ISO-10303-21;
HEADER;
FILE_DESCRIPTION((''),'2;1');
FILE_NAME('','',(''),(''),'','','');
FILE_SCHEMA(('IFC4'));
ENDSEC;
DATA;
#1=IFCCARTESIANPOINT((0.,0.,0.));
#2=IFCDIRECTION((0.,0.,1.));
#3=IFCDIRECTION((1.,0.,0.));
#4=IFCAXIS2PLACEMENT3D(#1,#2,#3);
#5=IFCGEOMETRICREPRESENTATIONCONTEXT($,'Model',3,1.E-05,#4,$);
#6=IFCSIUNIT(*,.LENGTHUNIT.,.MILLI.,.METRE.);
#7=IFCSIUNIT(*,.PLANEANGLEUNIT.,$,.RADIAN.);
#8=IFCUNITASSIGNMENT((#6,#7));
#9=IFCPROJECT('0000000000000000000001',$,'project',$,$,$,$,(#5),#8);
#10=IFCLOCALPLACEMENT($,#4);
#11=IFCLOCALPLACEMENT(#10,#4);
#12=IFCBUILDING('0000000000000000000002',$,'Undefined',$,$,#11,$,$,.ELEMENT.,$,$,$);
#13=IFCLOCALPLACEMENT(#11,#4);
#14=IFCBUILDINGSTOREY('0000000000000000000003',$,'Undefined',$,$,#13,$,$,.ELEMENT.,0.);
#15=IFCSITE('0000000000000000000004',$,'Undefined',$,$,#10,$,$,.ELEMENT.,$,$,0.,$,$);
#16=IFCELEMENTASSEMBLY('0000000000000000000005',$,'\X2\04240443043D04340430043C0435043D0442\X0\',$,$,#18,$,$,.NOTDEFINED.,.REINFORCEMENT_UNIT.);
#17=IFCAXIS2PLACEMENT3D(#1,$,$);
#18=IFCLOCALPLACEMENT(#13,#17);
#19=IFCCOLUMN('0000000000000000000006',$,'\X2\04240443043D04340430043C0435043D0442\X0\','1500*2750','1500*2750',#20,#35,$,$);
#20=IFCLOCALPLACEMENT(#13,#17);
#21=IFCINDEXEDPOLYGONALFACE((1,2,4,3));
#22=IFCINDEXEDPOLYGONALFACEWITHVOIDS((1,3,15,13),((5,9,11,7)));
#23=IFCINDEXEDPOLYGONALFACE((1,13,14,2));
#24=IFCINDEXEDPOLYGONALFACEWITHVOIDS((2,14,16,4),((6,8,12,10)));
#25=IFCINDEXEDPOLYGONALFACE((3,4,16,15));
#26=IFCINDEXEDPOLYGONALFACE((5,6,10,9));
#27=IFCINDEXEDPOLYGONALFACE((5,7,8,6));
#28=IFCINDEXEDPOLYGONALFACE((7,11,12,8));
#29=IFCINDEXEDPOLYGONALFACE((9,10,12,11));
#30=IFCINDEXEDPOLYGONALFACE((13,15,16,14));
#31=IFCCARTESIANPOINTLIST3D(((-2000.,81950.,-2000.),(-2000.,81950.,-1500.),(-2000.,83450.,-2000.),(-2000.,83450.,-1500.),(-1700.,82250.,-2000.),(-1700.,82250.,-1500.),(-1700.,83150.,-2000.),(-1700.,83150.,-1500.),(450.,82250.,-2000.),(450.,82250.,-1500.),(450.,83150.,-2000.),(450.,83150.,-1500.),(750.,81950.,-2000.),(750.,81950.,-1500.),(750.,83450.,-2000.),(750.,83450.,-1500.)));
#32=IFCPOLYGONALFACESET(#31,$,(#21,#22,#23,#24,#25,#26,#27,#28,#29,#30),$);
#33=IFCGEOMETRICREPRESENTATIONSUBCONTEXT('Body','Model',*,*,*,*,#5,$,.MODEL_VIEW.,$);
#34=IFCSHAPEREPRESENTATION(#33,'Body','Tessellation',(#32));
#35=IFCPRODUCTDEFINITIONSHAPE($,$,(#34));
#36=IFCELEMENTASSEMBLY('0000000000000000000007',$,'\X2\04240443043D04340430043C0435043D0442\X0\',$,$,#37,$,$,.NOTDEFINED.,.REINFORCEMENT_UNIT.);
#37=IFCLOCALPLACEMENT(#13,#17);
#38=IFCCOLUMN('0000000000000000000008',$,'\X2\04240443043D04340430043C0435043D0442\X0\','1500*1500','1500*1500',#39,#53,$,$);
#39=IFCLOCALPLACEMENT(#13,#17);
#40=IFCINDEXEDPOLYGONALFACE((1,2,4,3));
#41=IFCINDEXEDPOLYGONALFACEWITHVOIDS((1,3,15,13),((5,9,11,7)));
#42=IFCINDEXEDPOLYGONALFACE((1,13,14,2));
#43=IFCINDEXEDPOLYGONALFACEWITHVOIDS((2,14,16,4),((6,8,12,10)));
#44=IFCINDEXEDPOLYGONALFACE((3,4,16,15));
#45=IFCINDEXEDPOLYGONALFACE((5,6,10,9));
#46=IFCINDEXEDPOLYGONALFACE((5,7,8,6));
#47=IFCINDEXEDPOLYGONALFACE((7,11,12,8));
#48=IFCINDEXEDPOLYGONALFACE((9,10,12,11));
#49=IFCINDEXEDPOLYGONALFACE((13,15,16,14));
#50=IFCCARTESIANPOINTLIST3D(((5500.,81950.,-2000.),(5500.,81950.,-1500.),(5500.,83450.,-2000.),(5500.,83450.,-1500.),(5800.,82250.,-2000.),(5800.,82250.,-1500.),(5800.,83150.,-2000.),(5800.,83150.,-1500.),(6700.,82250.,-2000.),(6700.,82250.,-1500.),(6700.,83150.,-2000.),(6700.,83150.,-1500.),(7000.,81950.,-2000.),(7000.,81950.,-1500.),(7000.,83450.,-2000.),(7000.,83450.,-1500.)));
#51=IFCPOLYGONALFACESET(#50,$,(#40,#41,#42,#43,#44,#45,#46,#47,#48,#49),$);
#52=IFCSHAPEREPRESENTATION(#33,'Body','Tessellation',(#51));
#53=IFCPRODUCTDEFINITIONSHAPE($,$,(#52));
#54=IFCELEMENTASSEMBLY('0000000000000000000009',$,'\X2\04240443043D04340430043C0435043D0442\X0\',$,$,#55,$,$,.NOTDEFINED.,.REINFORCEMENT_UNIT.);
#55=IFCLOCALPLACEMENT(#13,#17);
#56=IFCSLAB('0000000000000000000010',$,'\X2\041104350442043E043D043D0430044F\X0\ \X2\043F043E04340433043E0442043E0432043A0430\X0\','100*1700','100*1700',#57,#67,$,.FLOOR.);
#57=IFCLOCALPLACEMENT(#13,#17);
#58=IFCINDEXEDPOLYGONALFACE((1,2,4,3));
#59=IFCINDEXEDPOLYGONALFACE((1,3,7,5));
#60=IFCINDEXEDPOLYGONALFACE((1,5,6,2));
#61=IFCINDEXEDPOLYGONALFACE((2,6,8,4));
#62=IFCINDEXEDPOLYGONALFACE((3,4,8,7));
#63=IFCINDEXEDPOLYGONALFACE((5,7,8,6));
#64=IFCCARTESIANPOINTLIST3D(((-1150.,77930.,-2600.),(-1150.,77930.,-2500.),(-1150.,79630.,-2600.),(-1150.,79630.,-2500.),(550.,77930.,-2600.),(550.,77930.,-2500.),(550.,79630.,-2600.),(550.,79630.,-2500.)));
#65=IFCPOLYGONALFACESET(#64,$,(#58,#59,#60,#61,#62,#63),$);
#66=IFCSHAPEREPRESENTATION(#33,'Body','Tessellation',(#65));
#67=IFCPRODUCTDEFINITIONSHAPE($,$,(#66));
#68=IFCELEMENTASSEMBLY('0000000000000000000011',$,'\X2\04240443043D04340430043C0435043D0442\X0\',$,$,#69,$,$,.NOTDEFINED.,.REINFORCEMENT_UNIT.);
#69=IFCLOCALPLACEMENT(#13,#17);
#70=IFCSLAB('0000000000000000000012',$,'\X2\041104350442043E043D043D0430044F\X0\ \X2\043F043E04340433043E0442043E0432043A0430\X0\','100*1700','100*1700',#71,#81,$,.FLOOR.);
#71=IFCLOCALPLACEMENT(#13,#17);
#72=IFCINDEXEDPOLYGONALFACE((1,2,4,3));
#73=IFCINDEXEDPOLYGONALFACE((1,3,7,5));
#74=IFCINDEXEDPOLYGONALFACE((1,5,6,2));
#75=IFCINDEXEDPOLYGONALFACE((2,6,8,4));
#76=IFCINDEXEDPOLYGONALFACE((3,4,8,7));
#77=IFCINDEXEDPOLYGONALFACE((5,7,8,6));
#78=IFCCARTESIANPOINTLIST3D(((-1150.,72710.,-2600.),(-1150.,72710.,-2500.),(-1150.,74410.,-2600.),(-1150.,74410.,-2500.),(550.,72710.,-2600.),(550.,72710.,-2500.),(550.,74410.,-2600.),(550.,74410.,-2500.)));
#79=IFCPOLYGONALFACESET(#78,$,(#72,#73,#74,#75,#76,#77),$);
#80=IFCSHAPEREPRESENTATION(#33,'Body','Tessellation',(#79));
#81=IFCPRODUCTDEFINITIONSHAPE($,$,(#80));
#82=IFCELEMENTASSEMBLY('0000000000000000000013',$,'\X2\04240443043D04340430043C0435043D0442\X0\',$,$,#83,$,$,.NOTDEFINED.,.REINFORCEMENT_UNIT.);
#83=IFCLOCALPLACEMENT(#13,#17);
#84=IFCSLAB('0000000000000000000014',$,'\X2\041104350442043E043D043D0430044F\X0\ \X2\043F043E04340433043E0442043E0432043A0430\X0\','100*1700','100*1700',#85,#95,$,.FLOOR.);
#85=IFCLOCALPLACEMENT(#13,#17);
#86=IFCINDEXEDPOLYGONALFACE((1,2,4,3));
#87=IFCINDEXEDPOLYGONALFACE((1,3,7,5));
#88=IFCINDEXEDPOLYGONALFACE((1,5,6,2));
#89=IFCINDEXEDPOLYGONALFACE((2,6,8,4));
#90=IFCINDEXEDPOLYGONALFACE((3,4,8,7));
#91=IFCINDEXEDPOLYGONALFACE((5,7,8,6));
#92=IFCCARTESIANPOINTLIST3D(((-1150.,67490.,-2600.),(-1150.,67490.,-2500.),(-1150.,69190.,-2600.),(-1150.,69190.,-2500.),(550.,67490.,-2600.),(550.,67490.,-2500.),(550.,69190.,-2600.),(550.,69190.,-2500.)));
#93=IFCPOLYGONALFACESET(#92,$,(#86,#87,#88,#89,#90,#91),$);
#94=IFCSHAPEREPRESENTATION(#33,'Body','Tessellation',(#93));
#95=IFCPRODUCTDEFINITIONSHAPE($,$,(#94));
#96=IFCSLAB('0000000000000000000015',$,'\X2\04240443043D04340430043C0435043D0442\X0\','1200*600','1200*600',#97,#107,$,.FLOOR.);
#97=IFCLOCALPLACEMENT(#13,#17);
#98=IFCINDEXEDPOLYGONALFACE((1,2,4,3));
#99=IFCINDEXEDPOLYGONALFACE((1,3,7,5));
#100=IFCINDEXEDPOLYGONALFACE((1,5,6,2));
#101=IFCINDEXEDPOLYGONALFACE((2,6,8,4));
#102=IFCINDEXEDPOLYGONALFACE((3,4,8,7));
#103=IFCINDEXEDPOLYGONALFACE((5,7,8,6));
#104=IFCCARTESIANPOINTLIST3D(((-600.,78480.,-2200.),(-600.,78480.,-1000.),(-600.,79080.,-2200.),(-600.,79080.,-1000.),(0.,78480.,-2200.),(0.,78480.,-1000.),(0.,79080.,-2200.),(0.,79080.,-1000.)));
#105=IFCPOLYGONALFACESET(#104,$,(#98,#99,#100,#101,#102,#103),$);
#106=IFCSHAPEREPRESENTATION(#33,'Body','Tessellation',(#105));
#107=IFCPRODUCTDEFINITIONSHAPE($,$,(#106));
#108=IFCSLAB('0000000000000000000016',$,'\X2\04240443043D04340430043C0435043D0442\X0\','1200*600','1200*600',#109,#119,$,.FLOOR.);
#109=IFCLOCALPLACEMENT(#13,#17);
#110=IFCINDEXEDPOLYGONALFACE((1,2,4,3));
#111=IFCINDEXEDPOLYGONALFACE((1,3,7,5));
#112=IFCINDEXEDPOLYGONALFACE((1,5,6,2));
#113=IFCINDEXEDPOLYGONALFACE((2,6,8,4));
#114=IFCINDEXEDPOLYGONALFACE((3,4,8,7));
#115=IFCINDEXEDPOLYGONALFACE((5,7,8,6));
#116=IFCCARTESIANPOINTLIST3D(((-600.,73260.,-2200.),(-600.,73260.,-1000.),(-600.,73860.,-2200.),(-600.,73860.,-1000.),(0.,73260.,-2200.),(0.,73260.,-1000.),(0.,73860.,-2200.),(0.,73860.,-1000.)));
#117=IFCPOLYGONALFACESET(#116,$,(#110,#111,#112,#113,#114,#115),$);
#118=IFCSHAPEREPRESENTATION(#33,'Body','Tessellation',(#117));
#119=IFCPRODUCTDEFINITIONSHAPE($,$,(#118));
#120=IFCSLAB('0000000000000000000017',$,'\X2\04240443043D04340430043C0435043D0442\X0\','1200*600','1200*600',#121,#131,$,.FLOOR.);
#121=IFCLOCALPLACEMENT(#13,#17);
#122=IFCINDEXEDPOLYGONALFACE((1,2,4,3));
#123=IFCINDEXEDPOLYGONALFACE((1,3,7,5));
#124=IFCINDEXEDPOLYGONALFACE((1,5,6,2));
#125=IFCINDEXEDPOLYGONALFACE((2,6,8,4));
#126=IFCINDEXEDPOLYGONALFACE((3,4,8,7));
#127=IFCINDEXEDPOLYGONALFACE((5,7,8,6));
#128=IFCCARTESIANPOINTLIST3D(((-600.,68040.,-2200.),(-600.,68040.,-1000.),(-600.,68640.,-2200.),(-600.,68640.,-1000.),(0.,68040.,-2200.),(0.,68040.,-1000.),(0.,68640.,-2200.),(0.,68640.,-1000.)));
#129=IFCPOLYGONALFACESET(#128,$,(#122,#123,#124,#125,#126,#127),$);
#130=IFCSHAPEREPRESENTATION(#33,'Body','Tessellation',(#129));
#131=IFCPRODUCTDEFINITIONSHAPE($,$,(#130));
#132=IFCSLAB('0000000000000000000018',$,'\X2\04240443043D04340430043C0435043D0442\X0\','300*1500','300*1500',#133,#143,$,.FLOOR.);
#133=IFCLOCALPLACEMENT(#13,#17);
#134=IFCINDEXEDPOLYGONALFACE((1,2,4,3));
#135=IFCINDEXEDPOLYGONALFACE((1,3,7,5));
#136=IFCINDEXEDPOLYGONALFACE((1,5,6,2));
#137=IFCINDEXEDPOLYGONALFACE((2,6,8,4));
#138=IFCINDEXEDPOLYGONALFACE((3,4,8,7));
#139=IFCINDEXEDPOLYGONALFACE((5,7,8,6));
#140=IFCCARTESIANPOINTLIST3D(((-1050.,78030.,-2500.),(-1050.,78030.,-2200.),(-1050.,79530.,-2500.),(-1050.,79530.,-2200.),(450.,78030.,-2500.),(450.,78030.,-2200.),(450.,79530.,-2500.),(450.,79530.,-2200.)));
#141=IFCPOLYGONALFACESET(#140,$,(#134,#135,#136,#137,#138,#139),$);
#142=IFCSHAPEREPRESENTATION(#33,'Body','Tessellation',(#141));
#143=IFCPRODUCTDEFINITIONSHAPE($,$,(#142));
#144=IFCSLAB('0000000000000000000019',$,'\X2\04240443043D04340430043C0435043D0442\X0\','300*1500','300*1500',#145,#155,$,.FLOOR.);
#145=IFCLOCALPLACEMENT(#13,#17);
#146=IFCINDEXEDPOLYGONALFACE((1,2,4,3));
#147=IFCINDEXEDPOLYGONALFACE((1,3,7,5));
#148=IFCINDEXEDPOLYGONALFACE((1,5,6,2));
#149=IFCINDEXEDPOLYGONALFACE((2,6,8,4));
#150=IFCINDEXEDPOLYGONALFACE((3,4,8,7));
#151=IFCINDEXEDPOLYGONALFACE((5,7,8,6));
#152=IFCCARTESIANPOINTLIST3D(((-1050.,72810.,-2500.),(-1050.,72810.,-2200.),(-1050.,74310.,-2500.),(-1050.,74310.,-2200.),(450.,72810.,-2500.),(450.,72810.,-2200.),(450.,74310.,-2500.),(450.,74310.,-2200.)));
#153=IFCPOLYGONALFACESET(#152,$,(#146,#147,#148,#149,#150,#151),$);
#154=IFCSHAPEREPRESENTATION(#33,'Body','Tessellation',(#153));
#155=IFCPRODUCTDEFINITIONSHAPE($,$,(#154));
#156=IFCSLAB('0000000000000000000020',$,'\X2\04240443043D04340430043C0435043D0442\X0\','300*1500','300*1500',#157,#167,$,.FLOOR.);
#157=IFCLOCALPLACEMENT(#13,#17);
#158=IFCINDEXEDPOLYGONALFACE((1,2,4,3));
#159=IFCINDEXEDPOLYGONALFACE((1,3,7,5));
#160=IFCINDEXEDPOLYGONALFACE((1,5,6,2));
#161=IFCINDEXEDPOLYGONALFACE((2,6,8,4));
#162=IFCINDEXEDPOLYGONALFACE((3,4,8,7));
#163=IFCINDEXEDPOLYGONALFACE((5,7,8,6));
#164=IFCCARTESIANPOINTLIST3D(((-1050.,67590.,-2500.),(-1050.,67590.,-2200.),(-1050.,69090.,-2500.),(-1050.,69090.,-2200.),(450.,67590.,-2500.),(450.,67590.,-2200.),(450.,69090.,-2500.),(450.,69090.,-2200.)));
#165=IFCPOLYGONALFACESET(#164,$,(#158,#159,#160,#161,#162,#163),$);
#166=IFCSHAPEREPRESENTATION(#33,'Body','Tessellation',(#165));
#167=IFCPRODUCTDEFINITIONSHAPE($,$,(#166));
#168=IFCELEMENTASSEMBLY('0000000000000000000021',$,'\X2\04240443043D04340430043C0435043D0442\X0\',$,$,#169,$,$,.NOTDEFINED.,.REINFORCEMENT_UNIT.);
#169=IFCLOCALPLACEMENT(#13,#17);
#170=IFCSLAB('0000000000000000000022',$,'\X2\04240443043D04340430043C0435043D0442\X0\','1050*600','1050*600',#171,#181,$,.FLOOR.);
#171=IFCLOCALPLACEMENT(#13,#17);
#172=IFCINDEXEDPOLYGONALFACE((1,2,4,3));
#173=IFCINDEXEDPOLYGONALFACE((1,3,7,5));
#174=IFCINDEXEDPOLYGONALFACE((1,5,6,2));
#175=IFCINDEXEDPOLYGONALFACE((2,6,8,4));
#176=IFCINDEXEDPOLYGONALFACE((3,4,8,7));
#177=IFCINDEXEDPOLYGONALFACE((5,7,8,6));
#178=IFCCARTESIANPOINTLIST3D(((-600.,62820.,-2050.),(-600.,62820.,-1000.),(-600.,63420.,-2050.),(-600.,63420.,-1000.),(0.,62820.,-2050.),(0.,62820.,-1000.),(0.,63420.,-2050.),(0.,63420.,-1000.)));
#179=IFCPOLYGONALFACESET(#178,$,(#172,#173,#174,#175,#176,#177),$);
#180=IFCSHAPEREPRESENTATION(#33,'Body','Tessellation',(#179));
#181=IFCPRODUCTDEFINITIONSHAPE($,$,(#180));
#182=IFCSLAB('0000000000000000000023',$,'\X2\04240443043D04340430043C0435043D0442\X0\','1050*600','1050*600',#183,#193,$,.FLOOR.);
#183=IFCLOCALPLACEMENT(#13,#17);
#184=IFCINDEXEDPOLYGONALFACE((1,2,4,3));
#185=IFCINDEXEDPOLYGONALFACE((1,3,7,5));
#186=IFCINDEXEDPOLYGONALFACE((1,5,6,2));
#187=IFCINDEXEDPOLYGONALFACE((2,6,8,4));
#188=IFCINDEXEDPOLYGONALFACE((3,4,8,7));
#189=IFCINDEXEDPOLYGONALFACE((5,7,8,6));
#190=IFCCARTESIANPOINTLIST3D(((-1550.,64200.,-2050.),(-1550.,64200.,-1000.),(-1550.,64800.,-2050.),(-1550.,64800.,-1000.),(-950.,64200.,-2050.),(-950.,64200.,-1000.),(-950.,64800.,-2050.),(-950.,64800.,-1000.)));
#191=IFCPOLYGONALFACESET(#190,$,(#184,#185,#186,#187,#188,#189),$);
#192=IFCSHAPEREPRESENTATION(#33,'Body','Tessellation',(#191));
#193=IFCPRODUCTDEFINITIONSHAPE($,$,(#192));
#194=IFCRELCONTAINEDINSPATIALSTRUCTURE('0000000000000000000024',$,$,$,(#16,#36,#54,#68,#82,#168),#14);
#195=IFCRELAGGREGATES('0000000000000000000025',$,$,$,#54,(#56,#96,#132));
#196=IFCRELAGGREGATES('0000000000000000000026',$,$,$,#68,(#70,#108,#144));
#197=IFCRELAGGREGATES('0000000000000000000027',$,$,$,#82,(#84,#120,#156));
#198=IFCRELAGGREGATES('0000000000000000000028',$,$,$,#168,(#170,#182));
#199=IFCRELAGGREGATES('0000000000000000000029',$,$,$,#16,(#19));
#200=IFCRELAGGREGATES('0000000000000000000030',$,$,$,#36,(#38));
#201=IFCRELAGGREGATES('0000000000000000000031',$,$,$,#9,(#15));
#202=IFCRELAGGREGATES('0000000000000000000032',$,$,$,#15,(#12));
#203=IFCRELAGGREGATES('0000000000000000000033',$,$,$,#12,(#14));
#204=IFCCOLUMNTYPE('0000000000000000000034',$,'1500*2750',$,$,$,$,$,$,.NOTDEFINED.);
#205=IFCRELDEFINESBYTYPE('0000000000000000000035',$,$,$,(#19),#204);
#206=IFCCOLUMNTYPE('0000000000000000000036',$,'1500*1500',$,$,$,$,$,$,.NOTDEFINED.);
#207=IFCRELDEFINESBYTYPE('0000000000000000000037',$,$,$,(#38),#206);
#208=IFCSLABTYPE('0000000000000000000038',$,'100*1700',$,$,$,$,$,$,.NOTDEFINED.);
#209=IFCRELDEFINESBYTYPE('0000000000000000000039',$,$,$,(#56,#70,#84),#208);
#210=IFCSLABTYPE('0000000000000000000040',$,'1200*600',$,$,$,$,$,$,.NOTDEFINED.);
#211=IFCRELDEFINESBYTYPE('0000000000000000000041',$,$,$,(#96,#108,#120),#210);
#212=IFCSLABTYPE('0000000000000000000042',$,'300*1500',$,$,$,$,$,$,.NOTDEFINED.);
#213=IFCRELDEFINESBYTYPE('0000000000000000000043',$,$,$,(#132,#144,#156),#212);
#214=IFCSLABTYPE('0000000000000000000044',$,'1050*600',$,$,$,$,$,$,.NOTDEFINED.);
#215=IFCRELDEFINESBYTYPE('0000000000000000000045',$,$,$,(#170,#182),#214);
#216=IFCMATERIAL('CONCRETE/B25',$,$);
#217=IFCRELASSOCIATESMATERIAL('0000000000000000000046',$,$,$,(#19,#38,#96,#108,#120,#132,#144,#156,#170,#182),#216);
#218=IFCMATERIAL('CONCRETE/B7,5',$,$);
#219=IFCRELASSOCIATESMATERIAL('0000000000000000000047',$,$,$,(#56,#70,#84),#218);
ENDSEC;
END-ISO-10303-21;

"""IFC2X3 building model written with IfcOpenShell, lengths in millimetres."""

from ifc_helpers import new_model, si_unit, frame, origin_with_axes, origin_2d_with_axis, place, context, subcontext, project, spatial, polyline, rectangle, outline, extrude, boolean, material, type_object, element, aggregate, save


model = new_model("IFC2X3")

# Units and contexts
model_context = context("Model", 3, precision=1e-05, world=origin_with_axes())
body_context = subcontext(model_context, "Body", "Model", "MODEL_VIEW")
ifc_project = project(units=[si_unit("LENGTHUNIT", "METRE", prefix="MILLI"), si_unit("PLANEANGLEUNIT", "RADIAN")], contexts=[model_context])

# Site, building, storey
site_placement = place(None, origin_with_axes())
site = spatial("IfcSite", under=ifc_project, at=site_placement, Name="Undefined", CompositionType="ELEMENT", RefElevation=0.0)
building_placement = place(site_placement, origin_with_axes())
building = spatial("IfcBuilding", under=site, at=building_placement, Name="Undefined", CompositionType="ELEMENT")
storey_placement = place(building_placement, origin_with_axes())
storey = spatial("IfcBuildingStorey", under=building, at=storey_placement, Name="Undefined", CompositionType="ELEMENT", Elevation=0.0)

# Element assemblies, columns
assembly_1_placement = place(storey_placement, origin_with_axes())
assembly_1 = element("IfcElementAssembly", 1, at=assembly_1_placement, inside=storey, Name="Фундамент", AssemblyPlace="NOTDEFINED", PredefinedType="REINFORCEMENT_UNIT")
ifc_material_1 = material(Name="CONCRETE/B25")
column_type_1 = type_object("IfcColumnType", Name="1500*2750", PredefinedType="NOTDEFINED")
column_1_placement = place(assembly_1_placement, frame((-625.0, 82700.0, -2000.0), z_axis=(0.0, 0.0, 1.0), x_axis=(0.0, -1.0, 0.0)))
column_1 = element("IfcColumn", 2, at=column_1_placement, type_object=column_type_1, material=ifc_material_1, Name="Фундамент", Description="1500*2750", ObjectType="1500*2750", context=body_context, shape_type="CSG", body=[
    boolean("DIFFERENCE", extrude(rectangle(XDim=2750.0, YDim=1500.0, at=origin_2d_with_axis()), frame((0.0, 0.0, 500.0), z_axis=(0.0, 0.0, -1.0), x_axis=(0.0, 1.0, 0.0)), (0.0, 0.0, 1.0), 500.0), extrude(outline(polyline([(0.0, 0.0), (900.0, 0.0), (900.0, 2150.0), (0.0, 2150.0), (0.0, 0.0)])), frame((-450.0, -1075.0, -100.0), z_axis=(0.0, 0.0, 1.0), x_axis=(1.0, 0.0, 0.0)), (0.0, 0.0, 1.0), 700.0)),
])
assembly_2_placement = place(storey_placement, origin_with_axes())
assembly_2 = element("IfcElementAssembly", 3, at=assembly_2_placement, inside=storey, Name="Фундамент", AssemblyPlace="NOTDEFINED", PredefinedType="REINFORCEMENT_UNIT")
column_type_2 = type_object("IfcColumnType", Name="1500*1500", PredefinedType="NOTDEFINED")
column_2_placement = place(assembly_2_placement, frame((6250.0, 82700.0, -2000.0), z_axis=(0.0, 0.0, 1.0), x_axis=(0.0, -1.0, 0.0)))
column_2 = element("IfcColumn", 4, at=column_2_placement, type_object=column_type_2, material=ifc_material_1, Name="Фундамент", Description="1500*1500", ObjectType="1500*1500", context=body_context, shape_type="CSG", body=[
    boolean("DIFFERENCE", extrude(rectangle(XDim=1500.0, YDim=1500.0, at=origin_2d_with_axis()), frame((0.0, 0.0, 500.0), z_axis=(0.0, 0.0, -1.0), x_axis=(0.0, 1.0, 0.0)), (0.0, 0.0, 1.0), 500.0), extrude(outline(polyline([(0.0, 0.0), (900.0, 0.0), (900.0, 900.0), (0.0, 900.0), (0.0, 0.0)])), frame((-450.0, -450.0, -100.0), z_axis=(0.0, 0.0, 1.0), x_axis=(1.0, 0.0, 0.0)), (0.0, 0.0, 1.0), 700.0)),
])

# Element assemblies, slabs
assembly_3_placement = place(storey_placement, origin_with_axes())
assembly_3 = element("IfcElementAssembly", 5, at=assembly_3_placement, inside=storey, Name="Фундамент", AssemblyPlace="NOTDEFINED", PredefinedType="REINFORCEMENT_UNIT")
ifc_material_2 = material(Name="CONCRETE/B7,5")
slab_type_1 = type_object("IfcSlabType", Name="100*1700", PredefinedType="NOTDEFINED")
slab_1_placement = place(assembly_3_placement, frame((-1150.0, 79630.0, -2550.0), z_axis=(0.0, 0.0, 1.0), x_axis=(0.0, -1.0, 0.0)))
slab_1 = element("IfcSlab", 6, at=slab_1_placement, type_object=slab_type_1, material=ifc_material_2, Name="Бетонная подготовка", Description="100*1700", ObjectType="100*1700", PredefinedType="FLOOR", context=body_context, shape_type="SweptSolid", body=[
    extrude(outline(polyline([(0.0, 0.0), (1700.0, 0.0), (1700.0, 1700.0), (0.0, 1700.0), (0.0, 0.0)])), frame((0.0, 0.0, -50.0), z_axis=(0.0, 0.0, 1.0), x_axis=(1.0, 0.0, 0.0)), (0.0, 0.0, 1.0), 100.0),
])
assembly_4_placement = place(storey_placement, origin_with_axes())
assembly_4 = element("IfcElementAssembly", 7, at=assembly_4_placement, inside=storey, Name="Фундамент", AssemblyPlace="NOTDEFINED", PredefinedType="REINFORCEMENT_UNIT")
slab_2_placement = place(assembly_4_placement, frame((-1150.0, 74410.0, -2550.0), z_axis=(0.0, 0.0, 1.0), x_axis=(0.0, -1.0, 0.0)))
slab_2 = element("IfcSlab", 8, at=slab_2_placement, type_object=slab_type_1, material=ifc_material_2, Name="Бетонная подготовка", Description="100*1700", ObjectType="100*1700", PredefinedType="FLOOR", context=body_context, shape_type="SweptSolid", body=[
    extrude(outline(polyline([(0.0, 0.0), (1700.0, 0.0), (1700.0, 1700.0), (0.0, 1700.0), (0.0, 0.0)])), frame((0.0, 0.0, -50.0), z_axis=(0.0, 0.0, 1.0), x_axis=(1.0, 0.0, 0.0)), (0.0, 0.0, 1.0), 100.0),
])
assembly_5_placement = place(storey_placement, origin_with_axes())
assembly_5 = element("IfcElementAssembly", 9, at=assembly_5_placement, inside=storey, Name="Фундамент", AssemblyPlace="NOTDEFINED", PredefinedType="REINFORCEMENT_UNIT")
slab_3_placement = place(assembly_5_placement, frame((-1150.0, 69190.0, -2550.0), z_axis=(0.0, 0.0, 1.0), x_axis=(0.0, -1.0, 0.0)))
slab_3 = element("IfcSlab", 10, at=slab_3_placement, type_object=slab_type_1, material=ifc_material_2, Name="Бетонная подготовка", Description="100*1700", ObjectType="100*1700", PredefinedType="FLOOR", context=body_context, shape_type="SweptSolid", body=[
    extrude(outline(polyline([(0.0, 0.0), (1700.0, 0.0), (1700.0, 1700.0), (0.0, 1700.0), (0.0, 0.0)])), frame((0.0, 0.0, -50.0), z_axis=(0.0, 0.0, 1.0), x_axis=(1.0, 0.0, 0.0)), (0.0, 0.0, 1.0), 100.0),
])

# Slabs
slab_type_2 = type_object("IfcSlabType", Name="1200*600", PredefinedType="NOTDEFINED")
slab_4_placement = place(assembly_3_placement, frame((-600.0, 79080.0, -1600.0), z_axis=(0.0, 0.0, 1.0), x_axis=(0.0, -1.0, 0.0)))
slab_4 = element("IfcSlab", 11, at=slab_4_placement, type_object=slab_type_2, material=ifc_material_1, Name="Фундамент", Description="1200*600", ObjectType="1200*600", PredefinedType="FLOOR", context=body_context, shape_type="SweptSolid", body=[
    extrude(outline(polyline([(0.0, 0.0), (600.0, 0.0), (600.0, 600.0), (0.0, 600.0), (0.0, 0.0)])), frame((0.0, 0.0, -600.0), z_axis=(0.0, 0.0, 1.0), x_axis=(1.0, 0.0, 0.0)), (0.0, 0.0, 1.0), 1200.0),
])
slab_5_placement = place(assembly_4_placement, frame((-600.0, 73860.0, -1600.0), z_axis=(0.0, 0.0, 1.0), x_axis=(0.0, -1.0, 0.0)))
slab_5 = element("IfcSlab", 12, at=slab_5_placement, type_object=slab_type_2, material=ifc_material_1, Name="Фундамент", Description="1200*600", ObjectType="1200*600", PredefinedType="FLOOR", context=body_context, shape_type="SweptSolid", body=[
    extrude(outline(polyline([(0.0, 0.0), (600.0, 0.0), (600.0, 600.0), (0.0, 600.0), (0.0, 0.0)])), frame((0.0, 0.0, -600.0), z_axis=(0.0, 0.0, 1.0), x_axis=(1.0, 0.0, 0.0)), (0.0, 0.0, 1.0), 1200.0),
])
slab_6_placement = place(assembly_5_placement, frame((-600.0, 68640.0, -1600.0), z_axis=(0.0, 0.0, 1.0), x_axis=(0.0, -1.0, 0.0)))
slab_6 = element("IfcSlab", 13, at=slab_6_placement, type_object=slab_type_2, material=ifc_material_1, Name="Фундамент", Description="1200*600", ObjectType="1200*600", PredefinedType="FLOOR", context=body_context, shape_type="SweptSolid", body=[
    extrude(outline(polyline([(0.0, 0.0), (600.0, 0.0), (600.0, 600.0), (0.0, 600.0), (0.0, 0.0)])), frame((0.0, 0.0, -600.0), z_axis=(0.0, 0.0, 1.0), x_axis=(1.0, 0.0, 0.0)), (0.0, 0.0, 1.0), 1200.0),
])
slab_type_3 = type_object("IfcSlabType", Name="300*1500", PredefinedType="NOTDEFINED")
slab_7_placement = place(assembly_3_placement, frame((-1050.0, 79530.0, -2350.0), z_axis=(0.0, 0.0, 1.0), x_axis=(0.0, -1.0, 0.0)))
slab_7 = element("IfcSlab", 14, at=slab_7_placement, type_object=slab_type_3, material=ifc_material_1, Name="Фундамент", Description="300*1500", ObjectType="300*1500", PredefinedType="FLOOR", context=body_context, shape_type="SweptSolid", body=[
    extrude(outline(polyline([(0.0, 0.0), (1500.0, 0.0), (1500.0, 1500.0), (0.0, 1500.0), (0.0, 0.0)])), frame((0.0, 0.0, -150.0), z_axis=(0.0, 0.0, 1.0), x_axis=(1.0, 0.0, 0.0)), (0.0, 0.0, 1.0), 300.0),
])
aggregate(assembly_3, [slab_1, slab_4, slab_7])
slab_8_placement = place(assembly_4_placement, frame((-1050.0, 74310.0, -2350.0), z_axis=(0.0, 0.0, 1.0), x_axis=(0.0, -1.0, 0.0)))
slab_8 = element("IfcSlab", 15, at=slab_8_placement, type_object=slab_type_3, material=ifc_material_1, Name="Фундамент", Description="300*1500", ObjectType="300*1500", PredefinedType="FLOOR", context=body_context, shape_type="SweptSolid", body=[
    extrude(outline(polyline([(0.0, 0.0), (1500.0, 0.0), (1500.0, 1500.0), (0.0, 1500.0), (0.0, 0.0)])), frame((0.0, 0.0, -150.0), z_axis=(0.0, 0.0, 1.0), x_axis=(1.0, 0.0, 0.0)), (0.0, 0.0, 1.0), 300.0),
])
aggregate(assembly_4, [slab_2, slab_5, slab_8])
slab_9_placement = place(assembly_5_placement, frame((-1050.0, 69090.0, -2350.0), z_axis=(0.0, 0.0, 1.0), x_axis=(0.0, -1.0, 0.0)))
slab_9 = element("IfcSlab", 16, at=slab_9_placement, type_object=slab_type_3, material=ifc_material_1, Name="Фундамент", Description="300*1500", ObjectType="300*1500", PredefinedType="FLOOR", context=body_context, shape_type="SweptSolid", body=[
    extrude(outline(polyline([(0.0, 0.0), (1500.0, 0.0), (1500.0, 1500.0), (0.0, 1500.0), (0.0, 0.0)])), frame((0.0, 0.0, -150.0), z_axis=(0.0, 0.0, 1.0), x_axis=(1.0, 0.0, 0.0)), (0.0, 0.0, 1.0), 300.0),
])
aggregate(assembly_5, [slab_3, slab_6, slab_9])

# Element assembly, slabs
assembly_6_placement = place(storey_placement, origin_with_axes())
assembly_6 = element("IfcElementAssembly", 17, at=assembly_6_placement, inside=storey, Name="Фундамент", AssemblyPlace="NOTDEFINED", PredefinedType="REINFORCEMENT_UNIT")
slab_type_4 = type_object("IfcSlabType", Name="1050*600", PredefinedType="NOTDEFINED")
slab_10_placement = place(assembly_6_placement, frame((-600.0, 63420.0, -1525.0), z_axis=(0.0, 0.0, 1.0), x_axis=(0.0, -1.0, 0.0)))
slab_10 = element("IfcSlab", 18, at=slab_10_placement, type_object=slab_type_4, material=ifc_material_1, Name="Фундамент", Description="1050*600", ObjectType="1050*600", PredefinedType="FLOOR", context=body_context, shape_type="SweptSolid", body=[
    extrude(outline(polyline([(0.0, 0.0), (600.0, 0.0), (600.0, 600.0), (0.0, 600.0), (0.0, 0.0)])), frame((0.0, 0.0, -525.0), z_axis=(0.0, 0.0, 1.0), x_axis=(1.0, 0.0, 0.0)), (0.0, 0.0, 1.0), 1050.0),
])
slab_11_placement = place(assembly_6_placement, frame((-1550.0, 64800.0, -1525.0), z_axis=(0.0, 0.0, 1.0), x_axis=(0.0, -1.0, 0.0)))
slab_11 = element("IfcSlab", 19, at=slab_11_placement, type_object=slab_type_4, material=ifc_material_1, Name="Фундамент", Description="1050*600", ObjectType="1050*600", PredefinedType="FLOOR", context=body_context, shape_type="SweptSolid", body=[
    extrude(outline(polyline([(0.0, 0.0), (600.0, 0.0), (600.0, 600.0), (0.0, 600.0), (0.0, 0.0)])), frame((0.0, 0.0, -525.0), z_axis=(0.0, 0.0, 1.0), x_axis=(1.0, 0.0, 0.0)), (0.0, 0.0, 1.0), 1050.0),
])
aggregate(assembly_6, [slab_10, slab_11])

aggregate(assembly_1, [column_1])
aggregate(assembly_2, [column_2])

save(model, "model.ifc")
